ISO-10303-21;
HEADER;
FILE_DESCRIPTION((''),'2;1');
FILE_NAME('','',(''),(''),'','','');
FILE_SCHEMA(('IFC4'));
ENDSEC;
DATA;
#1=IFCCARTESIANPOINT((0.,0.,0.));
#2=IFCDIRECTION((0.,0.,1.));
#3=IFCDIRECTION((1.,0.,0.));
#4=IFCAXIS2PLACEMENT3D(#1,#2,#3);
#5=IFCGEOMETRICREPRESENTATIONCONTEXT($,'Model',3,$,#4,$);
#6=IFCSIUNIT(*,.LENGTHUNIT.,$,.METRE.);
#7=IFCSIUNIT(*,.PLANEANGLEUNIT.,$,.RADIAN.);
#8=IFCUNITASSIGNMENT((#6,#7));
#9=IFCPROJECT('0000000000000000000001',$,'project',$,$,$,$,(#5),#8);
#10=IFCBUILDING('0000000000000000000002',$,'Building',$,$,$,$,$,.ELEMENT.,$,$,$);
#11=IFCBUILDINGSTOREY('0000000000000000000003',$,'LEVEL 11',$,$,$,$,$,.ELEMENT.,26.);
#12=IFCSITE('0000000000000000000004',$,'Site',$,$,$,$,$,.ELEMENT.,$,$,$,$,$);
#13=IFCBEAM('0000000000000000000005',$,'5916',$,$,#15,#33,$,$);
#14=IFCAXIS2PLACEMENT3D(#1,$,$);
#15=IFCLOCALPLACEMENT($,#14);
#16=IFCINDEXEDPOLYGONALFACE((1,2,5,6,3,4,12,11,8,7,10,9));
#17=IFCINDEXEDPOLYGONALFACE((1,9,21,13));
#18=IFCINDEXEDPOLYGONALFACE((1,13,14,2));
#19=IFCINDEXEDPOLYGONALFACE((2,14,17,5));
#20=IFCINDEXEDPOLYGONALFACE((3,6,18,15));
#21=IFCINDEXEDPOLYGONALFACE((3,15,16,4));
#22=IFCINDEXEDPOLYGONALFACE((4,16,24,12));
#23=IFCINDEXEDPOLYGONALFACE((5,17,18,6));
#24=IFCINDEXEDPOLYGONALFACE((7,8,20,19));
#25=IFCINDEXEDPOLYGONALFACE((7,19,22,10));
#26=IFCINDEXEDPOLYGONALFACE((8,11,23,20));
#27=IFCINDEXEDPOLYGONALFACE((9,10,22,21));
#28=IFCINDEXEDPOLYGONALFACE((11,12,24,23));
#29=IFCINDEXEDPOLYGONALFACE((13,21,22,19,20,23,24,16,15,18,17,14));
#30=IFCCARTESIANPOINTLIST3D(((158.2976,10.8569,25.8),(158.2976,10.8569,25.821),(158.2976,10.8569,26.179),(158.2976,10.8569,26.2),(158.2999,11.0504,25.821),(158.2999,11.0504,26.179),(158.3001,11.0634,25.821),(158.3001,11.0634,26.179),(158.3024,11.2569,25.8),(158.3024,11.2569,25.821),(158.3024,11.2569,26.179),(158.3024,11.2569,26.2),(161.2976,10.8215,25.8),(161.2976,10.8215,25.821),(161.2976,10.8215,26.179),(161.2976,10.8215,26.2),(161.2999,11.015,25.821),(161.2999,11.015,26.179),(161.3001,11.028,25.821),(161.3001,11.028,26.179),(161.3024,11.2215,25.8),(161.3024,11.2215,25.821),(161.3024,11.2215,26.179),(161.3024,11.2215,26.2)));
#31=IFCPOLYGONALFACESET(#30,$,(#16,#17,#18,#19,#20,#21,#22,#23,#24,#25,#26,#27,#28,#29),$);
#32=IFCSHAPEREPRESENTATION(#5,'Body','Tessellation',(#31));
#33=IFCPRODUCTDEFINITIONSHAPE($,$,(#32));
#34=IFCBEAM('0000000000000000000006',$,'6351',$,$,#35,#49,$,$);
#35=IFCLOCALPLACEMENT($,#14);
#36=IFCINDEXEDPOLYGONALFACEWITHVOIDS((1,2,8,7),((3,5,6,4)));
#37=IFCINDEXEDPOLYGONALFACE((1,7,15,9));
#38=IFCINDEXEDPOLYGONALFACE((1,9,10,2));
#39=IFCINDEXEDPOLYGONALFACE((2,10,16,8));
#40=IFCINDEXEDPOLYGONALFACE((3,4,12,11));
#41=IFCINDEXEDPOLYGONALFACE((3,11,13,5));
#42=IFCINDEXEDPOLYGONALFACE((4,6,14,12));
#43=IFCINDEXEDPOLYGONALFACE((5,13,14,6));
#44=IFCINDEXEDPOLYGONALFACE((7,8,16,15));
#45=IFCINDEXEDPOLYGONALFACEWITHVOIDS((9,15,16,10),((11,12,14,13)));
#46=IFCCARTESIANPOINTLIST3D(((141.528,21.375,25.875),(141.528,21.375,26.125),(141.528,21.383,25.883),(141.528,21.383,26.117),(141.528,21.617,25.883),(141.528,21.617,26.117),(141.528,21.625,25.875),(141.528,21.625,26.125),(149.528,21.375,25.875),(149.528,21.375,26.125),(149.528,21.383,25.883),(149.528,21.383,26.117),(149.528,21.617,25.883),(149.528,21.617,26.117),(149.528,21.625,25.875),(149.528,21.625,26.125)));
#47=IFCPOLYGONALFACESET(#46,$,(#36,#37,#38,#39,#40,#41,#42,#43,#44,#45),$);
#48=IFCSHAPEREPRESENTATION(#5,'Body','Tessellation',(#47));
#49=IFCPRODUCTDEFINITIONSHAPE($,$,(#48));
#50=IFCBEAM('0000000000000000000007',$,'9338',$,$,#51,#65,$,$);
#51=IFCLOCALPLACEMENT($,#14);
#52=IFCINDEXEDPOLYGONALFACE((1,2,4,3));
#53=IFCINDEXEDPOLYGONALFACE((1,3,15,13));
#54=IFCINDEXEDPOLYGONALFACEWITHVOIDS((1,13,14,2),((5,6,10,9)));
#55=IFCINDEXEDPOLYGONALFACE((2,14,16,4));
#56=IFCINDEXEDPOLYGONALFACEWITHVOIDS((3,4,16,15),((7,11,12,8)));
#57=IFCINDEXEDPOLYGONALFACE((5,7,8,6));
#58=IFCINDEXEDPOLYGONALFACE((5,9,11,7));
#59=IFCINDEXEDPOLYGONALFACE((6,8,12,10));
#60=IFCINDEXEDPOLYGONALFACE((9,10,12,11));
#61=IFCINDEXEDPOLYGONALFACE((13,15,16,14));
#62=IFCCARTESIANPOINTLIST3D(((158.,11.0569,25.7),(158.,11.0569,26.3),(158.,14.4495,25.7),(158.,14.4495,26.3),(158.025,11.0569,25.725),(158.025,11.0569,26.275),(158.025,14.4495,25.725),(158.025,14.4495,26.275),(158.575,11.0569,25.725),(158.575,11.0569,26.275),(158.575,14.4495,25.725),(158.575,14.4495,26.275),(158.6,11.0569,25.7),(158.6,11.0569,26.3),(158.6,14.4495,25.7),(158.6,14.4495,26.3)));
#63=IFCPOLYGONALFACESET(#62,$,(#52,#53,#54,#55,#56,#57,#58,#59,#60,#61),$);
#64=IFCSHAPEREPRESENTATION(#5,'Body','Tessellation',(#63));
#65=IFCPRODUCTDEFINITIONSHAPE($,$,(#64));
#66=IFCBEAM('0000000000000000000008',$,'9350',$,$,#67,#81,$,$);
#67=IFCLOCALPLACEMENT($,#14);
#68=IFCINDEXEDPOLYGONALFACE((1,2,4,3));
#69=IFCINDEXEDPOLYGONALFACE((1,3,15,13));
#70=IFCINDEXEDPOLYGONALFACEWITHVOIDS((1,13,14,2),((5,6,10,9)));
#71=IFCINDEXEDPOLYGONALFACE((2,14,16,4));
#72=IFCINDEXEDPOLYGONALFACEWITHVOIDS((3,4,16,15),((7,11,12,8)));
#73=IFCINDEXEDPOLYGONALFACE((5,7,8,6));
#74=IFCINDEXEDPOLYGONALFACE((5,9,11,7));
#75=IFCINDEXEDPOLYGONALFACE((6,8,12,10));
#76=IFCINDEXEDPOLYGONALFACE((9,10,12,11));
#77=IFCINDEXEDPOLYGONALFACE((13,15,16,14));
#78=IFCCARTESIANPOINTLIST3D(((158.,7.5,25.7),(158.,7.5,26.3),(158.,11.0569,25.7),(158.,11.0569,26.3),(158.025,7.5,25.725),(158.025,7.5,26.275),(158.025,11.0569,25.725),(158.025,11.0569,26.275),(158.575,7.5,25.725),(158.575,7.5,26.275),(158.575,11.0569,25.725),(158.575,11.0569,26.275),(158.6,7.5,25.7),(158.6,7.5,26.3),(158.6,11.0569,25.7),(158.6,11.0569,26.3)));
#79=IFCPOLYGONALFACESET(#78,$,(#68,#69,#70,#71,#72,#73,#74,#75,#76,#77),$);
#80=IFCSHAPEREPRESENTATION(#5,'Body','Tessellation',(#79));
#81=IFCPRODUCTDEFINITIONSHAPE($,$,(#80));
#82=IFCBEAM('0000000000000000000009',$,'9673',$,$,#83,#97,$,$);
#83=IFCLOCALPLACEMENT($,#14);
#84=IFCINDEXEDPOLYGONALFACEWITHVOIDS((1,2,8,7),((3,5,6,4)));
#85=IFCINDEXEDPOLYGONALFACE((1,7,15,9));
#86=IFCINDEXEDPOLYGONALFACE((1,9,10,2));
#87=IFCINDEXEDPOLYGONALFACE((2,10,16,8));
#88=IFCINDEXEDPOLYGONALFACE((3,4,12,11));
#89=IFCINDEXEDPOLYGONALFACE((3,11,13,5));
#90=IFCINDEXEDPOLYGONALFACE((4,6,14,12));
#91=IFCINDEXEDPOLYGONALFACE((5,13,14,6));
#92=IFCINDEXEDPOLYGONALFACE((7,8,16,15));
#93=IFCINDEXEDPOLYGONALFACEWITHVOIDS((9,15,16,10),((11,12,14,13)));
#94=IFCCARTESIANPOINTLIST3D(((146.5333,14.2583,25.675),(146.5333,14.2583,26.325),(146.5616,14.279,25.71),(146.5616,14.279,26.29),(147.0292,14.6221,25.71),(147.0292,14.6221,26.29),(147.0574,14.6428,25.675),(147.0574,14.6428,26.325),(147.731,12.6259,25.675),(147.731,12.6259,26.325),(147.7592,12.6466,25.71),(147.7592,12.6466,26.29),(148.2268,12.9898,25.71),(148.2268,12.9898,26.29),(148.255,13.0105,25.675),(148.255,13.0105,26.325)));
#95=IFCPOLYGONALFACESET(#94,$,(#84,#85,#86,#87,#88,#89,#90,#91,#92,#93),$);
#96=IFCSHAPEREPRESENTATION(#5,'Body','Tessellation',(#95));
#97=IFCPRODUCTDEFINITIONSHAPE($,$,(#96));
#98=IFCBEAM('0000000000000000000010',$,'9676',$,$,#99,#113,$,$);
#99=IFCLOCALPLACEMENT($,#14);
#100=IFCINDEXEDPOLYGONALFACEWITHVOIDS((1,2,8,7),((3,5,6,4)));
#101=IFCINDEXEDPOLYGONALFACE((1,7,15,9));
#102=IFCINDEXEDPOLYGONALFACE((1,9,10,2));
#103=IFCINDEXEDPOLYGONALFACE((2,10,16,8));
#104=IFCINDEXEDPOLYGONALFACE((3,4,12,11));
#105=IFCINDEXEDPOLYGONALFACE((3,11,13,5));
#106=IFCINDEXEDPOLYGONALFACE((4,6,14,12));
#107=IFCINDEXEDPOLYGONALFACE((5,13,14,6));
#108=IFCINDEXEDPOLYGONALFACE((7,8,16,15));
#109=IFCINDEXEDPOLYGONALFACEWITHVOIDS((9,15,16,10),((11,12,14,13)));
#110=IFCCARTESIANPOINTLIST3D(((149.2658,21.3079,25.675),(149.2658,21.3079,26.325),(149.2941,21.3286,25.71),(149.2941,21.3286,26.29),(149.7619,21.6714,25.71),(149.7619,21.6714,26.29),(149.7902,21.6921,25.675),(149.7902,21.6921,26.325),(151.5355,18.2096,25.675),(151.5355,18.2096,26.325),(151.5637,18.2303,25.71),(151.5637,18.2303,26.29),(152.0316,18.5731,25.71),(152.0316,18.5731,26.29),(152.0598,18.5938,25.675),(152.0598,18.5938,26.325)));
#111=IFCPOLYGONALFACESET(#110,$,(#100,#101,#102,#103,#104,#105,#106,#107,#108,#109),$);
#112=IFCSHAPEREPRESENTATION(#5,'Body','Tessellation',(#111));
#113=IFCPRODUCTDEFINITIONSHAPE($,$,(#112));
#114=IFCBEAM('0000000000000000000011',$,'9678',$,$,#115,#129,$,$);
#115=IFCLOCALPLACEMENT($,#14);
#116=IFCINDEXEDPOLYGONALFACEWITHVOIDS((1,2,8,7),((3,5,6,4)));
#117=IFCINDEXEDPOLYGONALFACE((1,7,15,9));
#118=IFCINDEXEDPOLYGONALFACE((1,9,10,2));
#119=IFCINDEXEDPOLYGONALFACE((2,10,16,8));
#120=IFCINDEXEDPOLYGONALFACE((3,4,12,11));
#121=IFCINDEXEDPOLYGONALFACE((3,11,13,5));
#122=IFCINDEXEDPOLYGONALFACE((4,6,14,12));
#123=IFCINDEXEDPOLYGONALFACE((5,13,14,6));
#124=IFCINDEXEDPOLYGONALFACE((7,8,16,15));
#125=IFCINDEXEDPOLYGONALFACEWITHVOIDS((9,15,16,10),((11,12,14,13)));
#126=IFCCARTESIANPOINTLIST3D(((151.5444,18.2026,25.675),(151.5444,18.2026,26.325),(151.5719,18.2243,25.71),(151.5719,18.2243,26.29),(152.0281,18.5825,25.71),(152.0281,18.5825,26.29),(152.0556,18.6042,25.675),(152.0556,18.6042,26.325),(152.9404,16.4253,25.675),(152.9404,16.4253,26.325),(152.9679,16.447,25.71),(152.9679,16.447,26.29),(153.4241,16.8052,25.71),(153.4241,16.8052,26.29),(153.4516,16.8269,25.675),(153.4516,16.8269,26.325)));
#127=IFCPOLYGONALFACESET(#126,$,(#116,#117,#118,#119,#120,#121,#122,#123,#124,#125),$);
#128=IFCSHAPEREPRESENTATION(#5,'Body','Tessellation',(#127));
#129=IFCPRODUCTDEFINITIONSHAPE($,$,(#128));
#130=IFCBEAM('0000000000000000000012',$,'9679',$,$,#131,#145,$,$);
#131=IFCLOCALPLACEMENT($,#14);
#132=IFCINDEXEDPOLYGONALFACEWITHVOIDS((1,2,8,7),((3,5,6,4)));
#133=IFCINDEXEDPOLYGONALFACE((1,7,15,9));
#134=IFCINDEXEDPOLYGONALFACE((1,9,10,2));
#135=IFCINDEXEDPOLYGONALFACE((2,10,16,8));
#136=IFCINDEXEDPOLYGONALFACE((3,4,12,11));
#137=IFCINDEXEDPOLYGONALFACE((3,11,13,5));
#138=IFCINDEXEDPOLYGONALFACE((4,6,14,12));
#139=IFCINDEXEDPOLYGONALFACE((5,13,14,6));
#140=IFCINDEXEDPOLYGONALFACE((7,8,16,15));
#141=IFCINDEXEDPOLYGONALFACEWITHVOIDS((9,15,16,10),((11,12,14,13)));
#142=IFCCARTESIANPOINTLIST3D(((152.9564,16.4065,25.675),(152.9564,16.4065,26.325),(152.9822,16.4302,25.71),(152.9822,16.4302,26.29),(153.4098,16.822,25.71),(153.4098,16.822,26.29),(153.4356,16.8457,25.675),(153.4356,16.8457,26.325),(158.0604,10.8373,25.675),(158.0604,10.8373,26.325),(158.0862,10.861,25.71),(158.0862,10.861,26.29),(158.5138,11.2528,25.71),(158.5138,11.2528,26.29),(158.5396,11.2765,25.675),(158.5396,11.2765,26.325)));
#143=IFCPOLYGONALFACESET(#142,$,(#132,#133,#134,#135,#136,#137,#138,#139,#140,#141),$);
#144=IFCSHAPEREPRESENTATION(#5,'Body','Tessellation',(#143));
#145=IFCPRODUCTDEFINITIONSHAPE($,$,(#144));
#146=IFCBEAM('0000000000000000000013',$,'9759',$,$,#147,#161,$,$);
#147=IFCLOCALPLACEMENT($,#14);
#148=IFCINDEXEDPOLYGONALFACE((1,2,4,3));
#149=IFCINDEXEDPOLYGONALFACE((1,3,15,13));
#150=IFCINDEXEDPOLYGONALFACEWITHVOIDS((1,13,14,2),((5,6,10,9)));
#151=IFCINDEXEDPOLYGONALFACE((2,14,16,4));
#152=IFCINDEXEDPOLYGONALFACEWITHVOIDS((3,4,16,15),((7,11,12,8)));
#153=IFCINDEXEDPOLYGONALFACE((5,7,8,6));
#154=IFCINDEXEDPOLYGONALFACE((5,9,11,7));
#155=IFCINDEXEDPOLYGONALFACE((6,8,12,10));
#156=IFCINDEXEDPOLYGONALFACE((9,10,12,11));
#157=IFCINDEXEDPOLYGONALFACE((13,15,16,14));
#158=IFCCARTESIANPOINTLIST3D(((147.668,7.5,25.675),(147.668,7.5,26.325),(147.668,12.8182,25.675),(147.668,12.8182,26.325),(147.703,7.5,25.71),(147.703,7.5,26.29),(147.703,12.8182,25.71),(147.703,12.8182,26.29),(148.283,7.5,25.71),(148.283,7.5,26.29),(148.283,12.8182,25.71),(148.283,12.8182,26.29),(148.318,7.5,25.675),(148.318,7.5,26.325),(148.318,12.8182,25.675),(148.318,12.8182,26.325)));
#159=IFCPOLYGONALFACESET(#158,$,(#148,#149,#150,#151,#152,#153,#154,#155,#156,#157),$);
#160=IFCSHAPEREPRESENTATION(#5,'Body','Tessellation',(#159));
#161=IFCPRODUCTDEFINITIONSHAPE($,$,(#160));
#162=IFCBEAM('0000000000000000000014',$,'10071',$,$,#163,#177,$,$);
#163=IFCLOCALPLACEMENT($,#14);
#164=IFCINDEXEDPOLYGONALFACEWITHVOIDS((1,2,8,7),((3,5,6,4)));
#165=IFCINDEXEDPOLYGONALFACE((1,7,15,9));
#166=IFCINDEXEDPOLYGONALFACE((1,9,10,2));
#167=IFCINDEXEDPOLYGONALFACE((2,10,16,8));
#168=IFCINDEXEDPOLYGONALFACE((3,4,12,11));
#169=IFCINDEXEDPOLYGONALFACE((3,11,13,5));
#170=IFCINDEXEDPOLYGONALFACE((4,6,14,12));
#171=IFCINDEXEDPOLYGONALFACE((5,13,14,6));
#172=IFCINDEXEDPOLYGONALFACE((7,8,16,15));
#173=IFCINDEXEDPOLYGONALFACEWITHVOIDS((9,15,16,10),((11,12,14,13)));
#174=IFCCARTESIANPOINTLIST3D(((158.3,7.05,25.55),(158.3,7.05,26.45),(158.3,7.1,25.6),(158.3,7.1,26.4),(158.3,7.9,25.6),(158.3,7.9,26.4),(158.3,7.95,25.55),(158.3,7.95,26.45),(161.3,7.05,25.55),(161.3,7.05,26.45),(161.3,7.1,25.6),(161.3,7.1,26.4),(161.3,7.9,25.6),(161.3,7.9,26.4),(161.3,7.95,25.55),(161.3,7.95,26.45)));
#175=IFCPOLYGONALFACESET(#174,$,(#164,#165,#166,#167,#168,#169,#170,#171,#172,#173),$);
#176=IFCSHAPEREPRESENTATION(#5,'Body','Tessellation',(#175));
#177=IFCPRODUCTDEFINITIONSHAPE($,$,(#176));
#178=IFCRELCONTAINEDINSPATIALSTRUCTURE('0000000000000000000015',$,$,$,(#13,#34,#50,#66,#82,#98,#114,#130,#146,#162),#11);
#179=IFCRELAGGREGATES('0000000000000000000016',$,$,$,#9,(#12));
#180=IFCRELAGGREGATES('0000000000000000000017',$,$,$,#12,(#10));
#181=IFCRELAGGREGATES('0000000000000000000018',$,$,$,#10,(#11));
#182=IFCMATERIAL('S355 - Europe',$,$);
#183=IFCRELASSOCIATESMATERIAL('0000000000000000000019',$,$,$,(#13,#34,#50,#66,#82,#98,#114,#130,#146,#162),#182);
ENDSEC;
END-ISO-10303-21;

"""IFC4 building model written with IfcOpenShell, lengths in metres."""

from ifc_helpers import new_model, si_unit, frame, origin_with_axes, origin_2d_with_axis, place, context, project, spatial, hollow_rectangle, i_section, extrude, material, material_profile, profile_set, profile_usage, element, save


model = new_model("IFC4")

# Units and contexts
model_context = context("Model", 3, world=origin_with_axes())
ifc_project = project(units=[si_unit("LENGTHUNIT", "METRE"), si_unit("PLANEANGLEUNIT", "RADIAN")], contexts=[model_context])

# Site, building, storey
site = spatial("IfcSite", under=ifc_project, Name="Site", CompositionType="ELEMENT")
building = spatial("IfcBuilding", under=site, Name="Building", CompositionType="ELEMENT")
storey = spatial("IfcBuildingStorey", under=building, Name="LEVEL 11", CompositionType="ELEMENT", Elevation=26.0)

# Shared definitions
ifc_material = material(Name="S355 - Europe")

# Beams
ifc_material_profile_1 = material_profile(ifc_material, i_section(OverallWidth=0.4, OverallDepth=0.4, WebThickness=0.013, FlangeThickness=0.021, at=origin_2d_with_axis()))
ifc_profile_set_1 = profile_set([ifc_material_profile_1])
ifc_profile_usage_1 = profile_usage(ifc_profile_set_1, cardinal=10)
beam_1_placement = place(None, frame((158.3, 11.0569, 26.0), z_axis=(0.99993, -0.011799, 0.0), x_axis=(0.011799, 0.99993, 0.0)))
element("IfcBeam", 1, at=beam_1_placement, inside=storey, material=ifc_profile_usage_1, Name="5916", context=model_context, shape_type="SweptSolid", body=[
    extrude(i_section(OverallWidth=0.4, OverallDepth=0.4, WebThickness=0.013, FlangeThickness=0.021, at=origin_2d_with_axis()), origin_with_axes(), (0.0, 0.0, 1.0), 3.0002),
])
ifc_material_profile_2 = material_profile(ifc_material, hollow_rectangle(XDim=0.25, YDim=0.25, WallThickness=0.008, at=origin_2d_with_axis()))
ifc_profile_set_2 = profile_set([ifc_material_profile_2])
ifc_profile_usage_2 = profile_usage(ifc_profile_set_2, cardinal=10)
beam_2_placement = place(None, frame((149.528, 21.5, 26.0), z_axis=(-1.0, 0.0, 0.0), x_axis=(0.0, -1.0, 0.0)))
element("IfcBeam", 2, at=beam_2_placement, inside=storey, material=ifc_profile_usage_2, Name="6351", context=model_context, shape_type="SweptSolid", body=[
    extrude(hollow_rectangle(XDim=0.25, YDim=0.25, WallThickness=0.008, at=origin_2d_with_axis()), origin_with_axes(), (0.0, 0.0, 1.0), 8.0),
])
ifc_material_profile_3 = material_profile(ifc_material, hollow_rectangle(XDim=0.6, YDim=0.6, WallThickness=0.025, at=origin_2d_with_axis()))
ifc_profile_set_3 = profile_set([ifc_material_profile_3])
ifc_profile_usage_3 = profile_usage(ifc_profile_set_3, cardinal=10)
beam_3_placement = place(None, frame((158.3, 14.4495, 26.0), z_axis=(0.0, -1.0, 0.0), x_axis=(1.0, 0.0, 0.0)))
element("IfcBeam", 3, at=beam_3_placement, inside=storey, material=ifc_profile_usage_3, Name="9338", context=model_context, shape_type="SweptSolid", body=[
    extrude(hollow_rectangle(XDim=0.6, YDim=0.6, WallThickness=0.025, at=origin_2d_with_axis()), origin_with_axes(), (0.0, 0.0, 1.0), 3.3926),
])
ifc_material_profile_4 = material_profile(ifc_material, hollow_rectangle(XDim=0.6, YDim=0.6, WallThickness=0.025, at=origin_2d_with_axis()))
ifc_profile_set_4 = profile_set([ifc_material_profile_4])
ifc_profile_usage_4 = profile_usage(ifc_profile_set_4, cardinal=10)
beam_4_placement = place(None, frame((158.3, 11.0569, 26.0), z_axis=(0.0, -1.0, 0.0), x_axis=(1.0, 0.0, 0.0)))
element("IfcBeam", 4, at=beam_4_placement, inside=storey, material=ifc_profile_usage_4, Name="9350", context=model_context, shape_type="SweptSolid", body=[
    extrude(hollow_rectangle(XDim=0.6, YDim=0.6, WallThickness=0.025, at=origin_2d_with_axis()), origin_with_axes(), (0.0, 0.0, 1.0), 3.5569),
])
ifc_material_profile_5 = material_profile(ifc_material, hollow_rectangle(XDim=0.65, YDim=0.65, WallThickness=0.035, at=origin_2d_with_axis()))
ifc_profile_set_5 = profile_set([ifc_material_profile_5])
ifc_profile_usage_5 = profile_usage(ifc_profile_set_5, cardinal=10)
beam_5_placement = place(None, frame((147.993, 12.8182, 26.0), z_axis=(-0.591557, 0.806263, 0.0), x_axis=(-0.805765, -0.592235, 0.0)))
element("IfcBeam", 5, at=beam_5_placement, inside=storey, material=ifc_profile_usage_5, Name="9673", context=model_context, shape_type="SweptSolid", body=[
    extrude(hollow_rectangle(XDim=0.65, YDim=0.65, WallThickness=0.035, at=origin_2d_with_axis()), origin_with_axes(), (0.0, 0.0, 1.0), 2.0245),
])
ifc_material_profile_6 = material_profile(ifc_material, hollow_rectangle(XDim=0.65, YDim=0.65, WallThickness=0.035, at=origin_2d_with_axis()))
ifc_profile_set_6 = profile_set([ifc_material_profile_6])
ifc_profile_usage_6 = profile_usage(ifc_profile_set_6, cardinal=10)
beam_6_placement = place(None, frame((149.528, 21.5, 26.0), z_axis=(0.590953, -0.806706, 0.0), x_axis=(0.806353, 0.591435, 0.0)))
element("IfcBeam", 6, at=beam_6_placement, inside=storey, material=ifc_profile_usage_6, Name="9676", context=model_context, shape_type="SweptSolid", body=[
    extrude(hollow_rectangle(XDim=0.65, YDim=0.65, WallThickness=0.035, at=origin_2d_with_axis()), origin_with_axes(), (0.0, 0.0, 1.0), 3.8407),
])
ifc_material_profile_7 = material_profile(ifc_material, hollow_rectangle(XDim=0.65, YDim=0.65, WallThickness=0.035, at=origin_2d_with_axis()))
ifc_profile_set_7 = profile_set([ifc_material_profile_7])
ifc_profile_usage_7 = profile_usage(ifc_profile_set_7, cardinal=10)
beam_7_placement = place(None, frame((151.8, 18.4034, 26.0), z_axis=(0.617698, -0.786415, 0.0), x_axis=(0.786415, 0.617698, 0.0)))
element("IfcBeam", 7, at=beam_7_placement, inside=storey, material=ifc_profile_usage_7, Name="9678", context=model_context, shape_type="SweptSolid", body=[
    extrude(hollow_rectangle(XDim=0.65, YDim=0.65, WallThickness=0.035, at=origin_2d_with_axis()), origin_with_axes(), (0.0, 0.0, 1.0), 2.26),
])
ifc_material_profile_8 = material_profile(ifc_material, hollow_rectangle(XDim=0.65, YDim=0.65, WallThickness=0.035, at=origin_2d_with_axis()))
ifc_profile_set_8 = profile_set([ifc_material_profile_8])
ifc_profile_usage_8 = profile_usage(ifc_profile_set_8, cardinal=10)
beam_8_placement = place(None, frame((153.196, 16.6261, 26.0), z_axis=(0.675646, -0.737227, 0.0), x_axis=(0.737227, 0.675646, 0.0)))
element("IfcBeam", 8, at=beam_8_placement, inside=storey, material=ifc_profile_usage_8, Name="9679", context=model_context, shape_type="SweptSolid", body=[
    extrude(hollow_rectangle(XDim=0.65, YDim=0.65, WallThickness=0.035, at=origin_2d_with_axis()), origin_with_axes(), (0.0, 0.0, 1.0), 7.5543),
])
ifc_material_profile_9 = material_profile(ifc_material, hollow_rectangle(XDim=0.65, YDim=0.65, WallThickness=0.035, at=origin_2d_with_axis()))
ifc_profile_set_9 = profile_set([ifc_material_profile_9])
ifc_profile_usage_9 = profile_usage(ifc_profile_set_9, cardinal=10)
beam_9_placement = place(None, frame((147.993, 12.8182, 26.0), z_axis=(0.0, -1.0, 0.0), x_axis=(1.0, 0.0, 0.0)))
element("IfcBeam", 9, at=beam_9_placement, inside=storey, material=ifc_profile_usage_9, Name="9759", context=model_context, shape_type="SweptSolid", body=[
    extrude(hollow_rectangle(XDim=0.65, YDim=0.65, WallThickness=0.035, at=origin_2d_with_axis()), origin_with_axes(), (0.0, 0.0, 1.0), 5.3182),
])
ifc_material_profile_10 = material_profile(ifc_material, hollow_rectangle(XDim=0.9, YDim=0.9, WallThickness=0.05, at=origin_2d_with_axis()))
ifc_profile_set_10 = profile_set([ifc_material_profile_10])
ifc_profile_usage_10 = profile_usage(ifc_profile_set_10, cardinal=10)
beam_10_placement = place(None, frame((158.3, 7.5, 26.0), z_axis=(1.0, 0.0, 0.0), x_axis=(0.0, 1.0, 0.0)))
element("IfcBeam", 10, at=beam_10_placement, inside=storey, material=ifc_profile_usage_10, Name="10071", context=model_context, shape_type="SweptSolid", body=[
    extrude(hollow_rectangle(XDim=0.9, YDim=0.9, WallThickness=0.05, at=origin_2d_with_axis()), origin_with_axes(), (0.0, 0.0, 1.0), 3.0),
])

save(model, "model.ifc")
